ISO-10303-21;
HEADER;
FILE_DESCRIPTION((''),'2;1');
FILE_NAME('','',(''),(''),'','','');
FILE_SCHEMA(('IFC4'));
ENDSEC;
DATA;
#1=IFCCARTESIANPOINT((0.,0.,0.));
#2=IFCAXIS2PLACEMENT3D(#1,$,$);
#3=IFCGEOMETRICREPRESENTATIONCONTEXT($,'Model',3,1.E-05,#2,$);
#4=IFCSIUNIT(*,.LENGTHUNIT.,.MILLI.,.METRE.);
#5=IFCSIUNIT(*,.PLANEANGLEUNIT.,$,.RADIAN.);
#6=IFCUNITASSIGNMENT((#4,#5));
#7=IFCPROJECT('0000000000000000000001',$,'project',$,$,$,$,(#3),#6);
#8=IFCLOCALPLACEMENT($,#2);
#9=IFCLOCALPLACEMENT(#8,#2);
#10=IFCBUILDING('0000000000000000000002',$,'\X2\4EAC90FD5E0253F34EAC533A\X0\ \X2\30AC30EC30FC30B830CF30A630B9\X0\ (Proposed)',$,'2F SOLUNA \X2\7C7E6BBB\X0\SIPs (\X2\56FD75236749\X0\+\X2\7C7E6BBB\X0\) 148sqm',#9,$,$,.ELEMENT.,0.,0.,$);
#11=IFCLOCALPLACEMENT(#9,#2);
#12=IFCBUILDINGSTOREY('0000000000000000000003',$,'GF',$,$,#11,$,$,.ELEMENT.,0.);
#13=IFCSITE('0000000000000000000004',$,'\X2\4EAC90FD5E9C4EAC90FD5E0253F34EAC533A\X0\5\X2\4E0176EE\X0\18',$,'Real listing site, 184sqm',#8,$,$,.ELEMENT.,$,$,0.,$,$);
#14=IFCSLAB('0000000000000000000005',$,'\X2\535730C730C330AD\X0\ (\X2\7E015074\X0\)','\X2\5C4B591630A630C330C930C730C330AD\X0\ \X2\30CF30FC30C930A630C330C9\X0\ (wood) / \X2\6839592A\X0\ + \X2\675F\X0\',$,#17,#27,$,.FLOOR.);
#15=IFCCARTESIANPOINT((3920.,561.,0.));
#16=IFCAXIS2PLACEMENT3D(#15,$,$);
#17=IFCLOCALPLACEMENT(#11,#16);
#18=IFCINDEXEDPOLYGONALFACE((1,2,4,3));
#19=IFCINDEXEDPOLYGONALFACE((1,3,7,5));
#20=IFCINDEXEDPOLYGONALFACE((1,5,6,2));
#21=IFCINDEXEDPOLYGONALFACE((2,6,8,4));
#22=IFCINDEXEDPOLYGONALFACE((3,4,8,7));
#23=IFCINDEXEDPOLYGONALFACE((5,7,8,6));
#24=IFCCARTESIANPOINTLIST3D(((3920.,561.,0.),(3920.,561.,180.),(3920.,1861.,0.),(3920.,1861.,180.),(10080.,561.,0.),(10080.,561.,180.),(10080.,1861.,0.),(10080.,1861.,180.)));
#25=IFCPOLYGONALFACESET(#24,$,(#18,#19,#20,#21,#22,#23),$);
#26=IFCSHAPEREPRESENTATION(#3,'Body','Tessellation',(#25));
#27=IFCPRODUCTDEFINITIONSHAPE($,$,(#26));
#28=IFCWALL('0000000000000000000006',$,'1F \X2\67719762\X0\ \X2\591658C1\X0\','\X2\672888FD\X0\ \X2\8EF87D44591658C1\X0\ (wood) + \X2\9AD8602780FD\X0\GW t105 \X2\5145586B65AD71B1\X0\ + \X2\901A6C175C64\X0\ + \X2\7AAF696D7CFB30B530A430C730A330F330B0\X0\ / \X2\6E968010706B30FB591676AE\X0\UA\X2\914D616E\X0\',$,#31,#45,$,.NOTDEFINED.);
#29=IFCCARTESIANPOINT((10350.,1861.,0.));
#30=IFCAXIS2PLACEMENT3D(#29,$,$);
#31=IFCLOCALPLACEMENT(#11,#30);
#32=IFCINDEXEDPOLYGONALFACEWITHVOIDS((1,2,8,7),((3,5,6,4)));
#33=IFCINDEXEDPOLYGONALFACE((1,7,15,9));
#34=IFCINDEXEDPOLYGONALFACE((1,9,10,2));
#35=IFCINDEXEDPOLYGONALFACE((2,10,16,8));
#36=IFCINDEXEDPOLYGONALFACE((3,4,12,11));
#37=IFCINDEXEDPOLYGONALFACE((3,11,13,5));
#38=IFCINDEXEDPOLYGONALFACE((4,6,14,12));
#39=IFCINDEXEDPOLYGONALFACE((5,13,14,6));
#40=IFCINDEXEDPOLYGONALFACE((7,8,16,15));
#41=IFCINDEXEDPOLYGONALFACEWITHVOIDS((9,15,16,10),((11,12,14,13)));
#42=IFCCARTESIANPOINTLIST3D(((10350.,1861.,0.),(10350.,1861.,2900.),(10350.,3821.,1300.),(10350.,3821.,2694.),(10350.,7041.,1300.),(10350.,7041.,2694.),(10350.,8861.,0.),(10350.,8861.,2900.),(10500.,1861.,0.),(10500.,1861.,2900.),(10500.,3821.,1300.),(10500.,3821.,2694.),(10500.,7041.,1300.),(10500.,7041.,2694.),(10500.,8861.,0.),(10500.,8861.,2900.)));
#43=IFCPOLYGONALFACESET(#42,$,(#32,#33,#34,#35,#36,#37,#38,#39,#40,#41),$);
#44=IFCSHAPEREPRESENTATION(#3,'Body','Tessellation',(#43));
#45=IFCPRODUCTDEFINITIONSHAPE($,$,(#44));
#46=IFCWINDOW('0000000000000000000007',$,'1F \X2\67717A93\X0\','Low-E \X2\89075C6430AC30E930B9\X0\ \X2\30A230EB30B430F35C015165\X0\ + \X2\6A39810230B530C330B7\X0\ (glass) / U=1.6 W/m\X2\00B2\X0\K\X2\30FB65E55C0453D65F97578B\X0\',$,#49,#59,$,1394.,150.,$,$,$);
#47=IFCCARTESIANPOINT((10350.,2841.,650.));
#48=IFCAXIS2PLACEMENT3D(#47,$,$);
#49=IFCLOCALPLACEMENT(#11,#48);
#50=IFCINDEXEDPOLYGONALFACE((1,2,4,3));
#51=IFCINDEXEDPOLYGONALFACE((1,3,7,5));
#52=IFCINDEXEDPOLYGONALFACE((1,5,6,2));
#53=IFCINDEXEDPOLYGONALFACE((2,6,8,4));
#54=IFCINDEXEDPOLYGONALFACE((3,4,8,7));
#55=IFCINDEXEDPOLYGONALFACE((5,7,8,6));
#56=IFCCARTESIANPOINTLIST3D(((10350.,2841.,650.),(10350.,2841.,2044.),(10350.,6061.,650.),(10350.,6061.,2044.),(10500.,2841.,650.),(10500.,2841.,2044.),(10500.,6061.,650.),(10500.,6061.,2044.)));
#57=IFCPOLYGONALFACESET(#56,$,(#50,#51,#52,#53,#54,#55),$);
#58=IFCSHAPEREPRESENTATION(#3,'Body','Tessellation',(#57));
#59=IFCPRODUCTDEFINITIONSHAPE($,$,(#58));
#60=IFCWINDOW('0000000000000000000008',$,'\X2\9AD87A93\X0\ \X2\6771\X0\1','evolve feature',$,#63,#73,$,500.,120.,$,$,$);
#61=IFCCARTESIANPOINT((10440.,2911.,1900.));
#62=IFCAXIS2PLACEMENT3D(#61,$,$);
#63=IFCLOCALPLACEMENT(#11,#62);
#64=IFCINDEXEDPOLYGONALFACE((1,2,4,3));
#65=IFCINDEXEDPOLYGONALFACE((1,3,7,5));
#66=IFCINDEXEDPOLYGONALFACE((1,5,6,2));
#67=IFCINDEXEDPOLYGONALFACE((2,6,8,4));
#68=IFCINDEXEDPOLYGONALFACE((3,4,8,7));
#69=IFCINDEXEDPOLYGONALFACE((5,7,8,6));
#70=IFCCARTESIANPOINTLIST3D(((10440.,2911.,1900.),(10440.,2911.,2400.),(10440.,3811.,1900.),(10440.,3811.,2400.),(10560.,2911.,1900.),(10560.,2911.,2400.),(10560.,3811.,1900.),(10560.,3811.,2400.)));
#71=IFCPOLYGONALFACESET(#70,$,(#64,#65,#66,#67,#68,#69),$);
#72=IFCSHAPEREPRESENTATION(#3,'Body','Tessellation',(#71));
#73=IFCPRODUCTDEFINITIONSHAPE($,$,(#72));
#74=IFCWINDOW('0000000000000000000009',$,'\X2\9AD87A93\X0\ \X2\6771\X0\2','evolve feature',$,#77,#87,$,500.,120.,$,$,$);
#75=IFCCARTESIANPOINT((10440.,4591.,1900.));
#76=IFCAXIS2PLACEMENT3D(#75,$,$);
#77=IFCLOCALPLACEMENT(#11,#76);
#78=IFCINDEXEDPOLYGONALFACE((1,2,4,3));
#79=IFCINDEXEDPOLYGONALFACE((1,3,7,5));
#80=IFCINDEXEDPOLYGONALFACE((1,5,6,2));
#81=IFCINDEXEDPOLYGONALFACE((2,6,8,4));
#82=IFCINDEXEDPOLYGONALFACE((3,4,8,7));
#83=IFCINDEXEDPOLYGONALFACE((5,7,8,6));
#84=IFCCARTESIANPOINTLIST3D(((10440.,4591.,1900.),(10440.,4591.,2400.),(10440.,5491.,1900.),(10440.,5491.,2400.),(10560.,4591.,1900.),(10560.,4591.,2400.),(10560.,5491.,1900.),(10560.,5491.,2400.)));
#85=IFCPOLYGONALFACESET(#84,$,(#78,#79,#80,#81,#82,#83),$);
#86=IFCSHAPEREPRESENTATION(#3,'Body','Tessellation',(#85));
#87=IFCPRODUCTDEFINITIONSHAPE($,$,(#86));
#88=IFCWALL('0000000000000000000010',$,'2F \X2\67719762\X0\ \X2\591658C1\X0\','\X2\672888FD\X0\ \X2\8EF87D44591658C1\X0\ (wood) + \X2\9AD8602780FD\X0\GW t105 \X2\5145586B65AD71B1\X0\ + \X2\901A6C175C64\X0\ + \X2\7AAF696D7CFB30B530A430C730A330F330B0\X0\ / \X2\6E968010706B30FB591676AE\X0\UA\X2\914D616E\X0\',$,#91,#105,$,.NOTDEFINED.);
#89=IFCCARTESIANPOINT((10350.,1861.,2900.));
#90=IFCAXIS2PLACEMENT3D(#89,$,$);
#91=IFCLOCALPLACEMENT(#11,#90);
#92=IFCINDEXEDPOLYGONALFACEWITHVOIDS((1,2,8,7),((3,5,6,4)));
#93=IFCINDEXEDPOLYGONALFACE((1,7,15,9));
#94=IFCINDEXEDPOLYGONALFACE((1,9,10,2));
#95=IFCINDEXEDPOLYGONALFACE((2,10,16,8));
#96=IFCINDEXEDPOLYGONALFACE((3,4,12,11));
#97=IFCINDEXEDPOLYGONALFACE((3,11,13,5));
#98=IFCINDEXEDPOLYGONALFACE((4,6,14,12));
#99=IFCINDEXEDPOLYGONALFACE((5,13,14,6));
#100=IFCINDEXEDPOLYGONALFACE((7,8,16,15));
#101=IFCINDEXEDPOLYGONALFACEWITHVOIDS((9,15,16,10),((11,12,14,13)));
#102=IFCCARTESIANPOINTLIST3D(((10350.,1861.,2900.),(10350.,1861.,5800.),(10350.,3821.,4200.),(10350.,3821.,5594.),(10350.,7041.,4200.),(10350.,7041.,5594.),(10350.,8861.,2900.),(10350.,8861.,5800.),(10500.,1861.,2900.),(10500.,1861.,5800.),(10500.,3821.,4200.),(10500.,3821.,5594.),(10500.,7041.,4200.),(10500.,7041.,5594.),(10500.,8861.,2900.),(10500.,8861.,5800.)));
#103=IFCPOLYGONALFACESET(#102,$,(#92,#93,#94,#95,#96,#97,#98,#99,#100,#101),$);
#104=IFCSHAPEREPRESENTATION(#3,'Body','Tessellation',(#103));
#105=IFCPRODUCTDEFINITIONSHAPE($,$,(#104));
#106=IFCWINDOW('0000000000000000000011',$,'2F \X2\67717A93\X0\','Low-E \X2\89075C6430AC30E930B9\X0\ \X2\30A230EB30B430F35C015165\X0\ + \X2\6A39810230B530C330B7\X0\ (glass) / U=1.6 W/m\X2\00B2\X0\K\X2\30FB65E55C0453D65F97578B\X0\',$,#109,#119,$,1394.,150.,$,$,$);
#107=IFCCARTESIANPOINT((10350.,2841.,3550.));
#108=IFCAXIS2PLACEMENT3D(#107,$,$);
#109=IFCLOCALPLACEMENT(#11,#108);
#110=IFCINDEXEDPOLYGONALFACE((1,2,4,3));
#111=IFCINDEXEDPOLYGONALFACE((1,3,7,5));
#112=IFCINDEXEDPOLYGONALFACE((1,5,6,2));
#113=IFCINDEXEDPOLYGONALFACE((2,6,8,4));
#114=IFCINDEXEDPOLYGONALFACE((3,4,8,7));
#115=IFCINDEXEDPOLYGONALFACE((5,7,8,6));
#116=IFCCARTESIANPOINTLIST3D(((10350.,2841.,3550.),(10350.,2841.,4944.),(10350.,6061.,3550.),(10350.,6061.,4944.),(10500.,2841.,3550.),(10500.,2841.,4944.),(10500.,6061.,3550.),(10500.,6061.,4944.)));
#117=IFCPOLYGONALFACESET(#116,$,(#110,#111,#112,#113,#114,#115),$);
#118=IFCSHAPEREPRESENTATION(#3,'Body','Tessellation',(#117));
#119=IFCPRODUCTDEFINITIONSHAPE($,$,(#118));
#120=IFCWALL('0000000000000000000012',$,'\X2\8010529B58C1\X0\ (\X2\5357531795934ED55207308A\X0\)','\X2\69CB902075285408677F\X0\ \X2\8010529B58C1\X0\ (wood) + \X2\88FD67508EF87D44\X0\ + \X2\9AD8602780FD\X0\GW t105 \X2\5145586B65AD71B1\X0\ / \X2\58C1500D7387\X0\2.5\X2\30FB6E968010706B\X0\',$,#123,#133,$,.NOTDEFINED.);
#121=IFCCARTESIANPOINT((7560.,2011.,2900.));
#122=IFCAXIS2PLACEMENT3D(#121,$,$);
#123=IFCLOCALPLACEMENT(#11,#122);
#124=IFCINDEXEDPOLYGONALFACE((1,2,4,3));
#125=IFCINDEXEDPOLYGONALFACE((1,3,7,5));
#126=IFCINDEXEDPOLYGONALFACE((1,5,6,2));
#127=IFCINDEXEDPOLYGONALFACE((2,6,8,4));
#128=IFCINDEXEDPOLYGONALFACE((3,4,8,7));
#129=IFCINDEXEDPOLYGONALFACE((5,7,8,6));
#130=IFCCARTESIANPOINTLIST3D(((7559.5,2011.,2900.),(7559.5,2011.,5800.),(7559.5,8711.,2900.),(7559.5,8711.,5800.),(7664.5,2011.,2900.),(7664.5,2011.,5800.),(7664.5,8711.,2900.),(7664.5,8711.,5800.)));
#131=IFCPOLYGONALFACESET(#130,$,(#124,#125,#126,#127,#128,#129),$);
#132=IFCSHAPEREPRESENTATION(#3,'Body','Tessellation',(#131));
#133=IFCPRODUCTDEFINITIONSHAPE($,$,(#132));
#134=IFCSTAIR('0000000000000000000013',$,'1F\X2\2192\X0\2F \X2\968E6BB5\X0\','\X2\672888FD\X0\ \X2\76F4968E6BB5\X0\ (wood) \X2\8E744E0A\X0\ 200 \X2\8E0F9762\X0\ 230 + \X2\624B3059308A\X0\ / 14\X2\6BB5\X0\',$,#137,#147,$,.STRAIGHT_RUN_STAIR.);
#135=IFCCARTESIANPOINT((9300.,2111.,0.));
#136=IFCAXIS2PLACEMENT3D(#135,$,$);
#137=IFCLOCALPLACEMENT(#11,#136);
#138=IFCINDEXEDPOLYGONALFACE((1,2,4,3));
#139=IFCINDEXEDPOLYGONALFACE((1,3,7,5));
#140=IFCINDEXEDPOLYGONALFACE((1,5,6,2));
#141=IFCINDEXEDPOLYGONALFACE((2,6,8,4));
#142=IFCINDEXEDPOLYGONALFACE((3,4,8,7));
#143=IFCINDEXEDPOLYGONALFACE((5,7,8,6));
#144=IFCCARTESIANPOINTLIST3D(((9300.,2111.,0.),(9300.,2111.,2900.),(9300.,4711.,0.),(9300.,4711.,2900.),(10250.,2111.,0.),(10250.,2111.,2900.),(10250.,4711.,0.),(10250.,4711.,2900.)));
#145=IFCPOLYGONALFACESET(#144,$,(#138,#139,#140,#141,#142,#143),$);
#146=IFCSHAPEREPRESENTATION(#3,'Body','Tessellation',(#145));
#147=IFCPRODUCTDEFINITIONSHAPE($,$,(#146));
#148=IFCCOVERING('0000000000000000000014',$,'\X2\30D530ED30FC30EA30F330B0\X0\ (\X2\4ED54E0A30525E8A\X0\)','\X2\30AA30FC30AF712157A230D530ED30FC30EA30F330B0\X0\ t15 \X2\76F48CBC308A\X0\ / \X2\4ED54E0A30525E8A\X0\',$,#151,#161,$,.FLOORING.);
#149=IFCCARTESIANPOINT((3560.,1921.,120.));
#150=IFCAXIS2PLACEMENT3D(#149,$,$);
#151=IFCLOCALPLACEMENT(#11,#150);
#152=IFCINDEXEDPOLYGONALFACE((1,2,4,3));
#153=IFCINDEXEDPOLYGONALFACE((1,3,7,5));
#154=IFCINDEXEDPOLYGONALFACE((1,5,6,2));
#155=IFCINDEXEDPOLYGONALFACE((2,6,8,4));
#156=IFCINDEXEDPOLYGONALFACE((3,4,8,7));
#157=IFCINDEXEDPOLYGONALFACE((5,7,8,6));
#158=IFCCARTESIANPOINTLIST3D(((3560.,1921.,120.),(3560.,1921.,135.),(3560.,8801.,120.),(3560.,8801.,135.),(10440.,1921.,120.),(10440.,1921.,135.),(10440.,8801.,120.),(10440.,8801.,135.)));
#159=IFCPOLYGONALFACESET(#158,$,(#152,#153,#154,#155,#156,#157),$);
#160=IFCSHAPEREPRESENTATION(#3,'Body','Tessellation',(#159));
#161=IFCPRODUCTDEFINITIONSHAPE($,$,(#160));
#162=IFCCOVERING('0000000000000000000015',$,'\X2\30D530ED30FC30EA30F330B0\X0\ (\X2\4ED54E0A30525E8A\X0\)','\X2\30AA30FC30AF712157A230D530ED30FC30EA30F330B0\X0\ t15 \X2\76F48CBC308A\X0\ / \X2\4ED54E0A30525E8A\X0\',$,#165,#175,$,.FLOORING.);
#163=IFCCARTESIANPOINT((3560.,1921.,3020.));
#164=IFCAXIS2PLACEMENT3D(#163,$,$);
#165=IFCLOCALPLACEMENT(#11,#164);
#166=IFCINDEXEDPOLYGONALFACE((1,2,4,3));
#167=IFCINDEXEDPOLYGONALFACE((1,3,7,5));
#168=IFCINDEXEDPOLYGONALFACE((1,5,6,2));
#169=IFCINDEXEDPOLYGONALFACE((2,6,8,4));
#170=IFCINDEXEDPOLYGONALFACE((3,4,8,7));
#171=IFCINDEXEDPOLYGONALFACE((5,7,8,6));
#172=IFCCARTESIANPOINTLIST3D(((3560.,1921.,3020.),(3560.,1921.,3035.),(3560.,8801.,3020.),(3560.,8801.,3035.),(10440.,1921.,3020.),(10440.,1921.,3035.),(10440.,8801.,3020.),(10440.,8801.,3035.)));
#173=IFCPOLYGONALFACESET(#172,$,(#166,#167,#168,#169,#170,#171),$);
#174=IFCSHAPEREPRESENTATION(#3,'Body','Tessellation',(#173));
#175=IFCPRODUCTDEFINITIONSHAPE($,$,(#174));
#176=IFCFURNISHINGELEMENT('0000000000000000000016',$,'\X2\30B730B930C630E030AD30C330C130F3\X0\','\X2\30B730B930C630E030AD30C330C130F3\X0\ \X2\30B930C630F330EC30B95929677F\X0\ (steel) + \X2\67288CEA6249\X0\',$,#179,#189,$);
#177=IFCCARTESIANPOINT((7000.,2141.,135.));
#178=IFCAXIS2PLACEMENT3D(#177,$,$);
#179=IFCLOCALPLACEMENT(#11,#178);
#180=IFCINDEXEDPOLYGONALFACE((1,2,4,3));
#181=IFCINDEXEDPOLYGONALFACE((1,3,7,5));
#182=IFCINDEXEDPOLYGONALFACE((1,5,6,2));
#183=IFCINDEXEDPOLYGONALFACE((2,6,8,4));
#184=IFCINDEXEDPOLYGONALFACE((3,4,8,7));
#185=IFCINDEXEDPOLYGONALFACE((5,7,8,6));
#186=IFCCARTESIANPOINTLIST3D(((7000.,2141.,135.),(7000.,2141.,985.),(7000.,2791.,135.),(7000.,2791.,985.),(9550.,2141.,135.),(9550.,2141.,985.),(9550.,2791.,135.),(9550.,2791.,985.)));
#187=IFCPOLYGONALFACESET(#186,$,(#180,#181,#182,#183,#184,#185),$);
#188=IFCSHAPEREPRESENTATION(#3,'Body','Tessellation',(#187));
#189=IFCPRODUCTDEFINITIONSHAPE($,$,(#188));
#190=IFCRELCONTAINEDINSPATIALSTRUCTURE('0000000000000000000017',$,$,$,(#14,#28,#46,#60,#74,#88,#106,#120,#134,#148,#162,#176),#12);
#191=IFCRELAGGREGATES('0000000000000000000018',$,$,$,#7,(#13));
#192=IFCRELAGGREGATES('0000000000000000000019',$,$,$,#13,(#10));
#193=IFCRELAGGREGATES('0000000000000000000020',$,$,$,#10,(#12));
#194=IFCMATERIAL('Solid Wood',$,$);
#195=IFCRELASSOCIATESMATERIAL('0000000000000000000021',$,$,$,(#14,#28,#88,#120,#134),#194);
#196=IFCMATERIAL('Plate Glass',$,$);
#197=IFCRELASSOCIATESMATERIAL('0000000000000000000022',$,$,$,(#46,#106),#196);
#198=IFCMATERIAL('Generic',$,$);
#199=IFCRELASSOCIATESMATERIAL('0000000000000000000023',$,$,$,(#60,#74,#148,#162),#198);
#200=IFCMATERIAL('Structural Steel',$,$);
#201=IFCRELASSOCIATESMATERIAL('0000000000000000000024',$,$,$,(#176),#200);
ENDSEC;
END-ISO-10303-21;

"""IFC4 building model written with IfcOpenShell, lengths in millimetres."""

from ifc_helpers import new_model, si_unit, frame, frame_2d, origin, place, context, project, spatial, rectangle, extrude, material, element, fill, save


model = new_model("IFC4")

# Units and contexts
model_context = context("Model", 3, precision=1e-05, world=origin())
ifc_project = project(units=[si_unit("LENGTHUNIT", "METRE", prefix="MILLI"), si_unit("PLANEANGLEUNIT", "RADIAN")], contexts=[model_context])

# Site, building, storey
site_placement = place(None, origin())
site = spatial("IfcSite", under=ifc_project, at=site_placement, Name="京都府京都市右京区5丁目18", ObjectType="Real listing site, 184sqm", CompositionType="ELEMENT", RefElevation=0.0)
building_placement = place(site_placement, origin())
building = spatial("IfcBuilding", under=site, at=building_placement, Name="京都市右京区 ガレージハウス (Proposed)", ObjectType="2F SOLUNA 籾殻SIPs (国産杉+籾殻) 148sqm", CompositionType="ELEMENT", ElevationOfRefHeight=0.0, ElevationOfTerrain=0.0)
storey_placement = place(building_placement, origin())
storey = spatial("IfcBuildingStorey", under=building, at=storey_placement, Name="GF", CompositionType="ELEMENT", Elevation=0.0)

# Slab
ifc_material_1 = material(Name="Solid Wood")
slab_placement = place(storey_placement, frame((3920.0, 561.0, 0.0)))
element("IfcSlab", 1, at=slab_placement, inside=storey, material=ifc_material_1, Name="南デッキ (縁側)", Description="屋外ウッドデッキ ハードウッド (wood) / 根太 + 束", PredefinedType="FLOOR", context=model_context, shape_type="SweptSolid", body=[
    extrude(rectangle(XDim=6160.0, YDim=1300.0, at=frame_2d((3080.0, 650.0))), frame((3920.0, 561.0, 0.0)), (0.0, 0.0, 1.0), 180.0),
])

# Wall, openings, windows
wall_1_placement = place(storey_placement, frame((10350.0, 1861.0, 0.0)))
wall_1 = element("IfcWall", 2, at=wall_1_placement, inside=storey, material=ifc_material_1, Name="1F 東面 外壁", Description="木製 軸組外壁 (wood) + 高性能GW t105 充填断熱 + 通気層 + 窯業系サイディング / 準耐火・外皮UA配慮", PredefinedType="NOTDEFINED", context=model_context, shape_type="SweptSolid", body=[
    extrude(rectangle(XDim=150.0, YDim=7000.0, at=frame_2d((75.0, 3500.0))), frame((10350.0, 1861.0, 0.0)), (0.0, 0.0, 1.0), 2900.0),
])
opening_1_placement = place(storey_placement, frame((10350.0, 2841.0, 650.0)))
opening_1 = element("IfcOpeningElement", 3, at=opening_1_placement, cuts=wall_1, PredefinedType="NOTDEFINED", context=model_context, shape_type="SweptSolid", body=[
    extrude(rectangle(XDim=150.0, YDim=3220.0, at=frame_2d((75.0, 1610.0))), frame((10350.0, 2841.0, 650.0)), (0.0, 0.0, 1.0), 1394.0),
])
opening_2_placement = place(storey_placement, frame((10440.0, 2911.0, 1900.0)))
opening_2 = element("IfcOpeningElement", 4, at=opening_2_placement, cuts=wall_1, PredefinedType="NOTDEFINED", context=model_context, shape_type="SweptSolid", body=[
    extrude(rectangle(XDim=120.0, YDim=900.0, at=frame_2d((60.0, 450.0))), frame((10440.0, 2911.0, 1900.0)), (0.0, 0.0, 1.0), 500.0),
])
opening_3_placement = place(storey_placement, frame((10440.0, 4591.0, 1900.0)))
opening_3 = element("IfcOpeningElement", 5, at=opening_3_placement, cuts=wall_1, PredefinedType="NOTDEFINED", context=model_context, shape_type="SweptSolid", body=[
    extrude(rectangle(XDim=120.0, YDim=900.0, at=frame_2d((60.0, 450.0))), frame((10440.0, 4591.0, 1900.0)), (0.0, 0.0, 1.0), 500.0),
])
ifc_material_2 = material(Name="Plate Glass")
window_1_placement = place(storey_placement, frame((10350.0, 2841.0, 650.0)))
window_1 = element("IfcWindow", 6, at=window_1_placement, inside=storey, material=ifc_material_2, Name="1F 東窓", Description="Low-E 複層ガラス アルゴン封入 + 樹脂サッシ (glass) / U=1.6 W/m²K・日射取得型", OverallHeight=1394.0, OverallWidth=150.0, context=model_context, shape_type="SweptSolid", body=[
    extrude(rectangle(XDim=150.0, YDim=3220.0, at=frame_2d((75.0, 1610.0))), frame((10350.0, 2841.0, 650.0)), (0.0, 0.0, 1.0), 1394.0),
])
fill(opening_1, window_1)
ifc_material_3 = material(Name="Generic")
window_2_placement = place(storey_placement, frame((10440.0, 2911.0, 1900.0)))
window_2 = element("IfcWindow", 7, at=window_2_placement, inside=storey, material=ifc_material_3, Name="高窓 東1", Description="evolve feature", OverallHeight=500.0, OverallWidth=120.0, context=model_context, shape_type="SweptSolid", body=[
    extrude(rectangle(XDim=120.0, YDim=900.0, at=frame_2d((60.0, 450.0))), frame((10440.0, 2911.0, 1900.0)), (0.0, 0.0, 1.0), 500.0),
])
fill(opening_2, window_2)
window_3_placement = place(storey_placement, frame((10440.0, 4591.0, 1900.0)))
window_3 = element("IfcWindow", 8, at=window_3_placement, inside=storey, material=ifc_material_3, Name="高窓 東2", Description="evolve feature", OverallHeight=500.0, OverallWidth=120.0, context=model_context, shape_type="SweptSolid", body=[
    extrude(rectangle(XDim=120.0, YDim=900.0, at=frame_2d((60.0, 450.0))), frame((10440.0, 4591.0, 1900.0)), (0.0, 0.0, 1.0), 500.0),
])
fill(opening_3, window_3)

# Wall, opening, window
wall_2_placement = place(storey_placement, frame((10350.0, 1861.0, 2900.0)))
wall_2 = element("IfcWall", 9, at=wall_2_placement, inside=storey, material=ifc_material_1, Name="2F 東面 外壁", Description="木製 軸組外壁 (wood) + 高性能GW t105 充填断熱 + 通気層 + 窯業系サイディング / 準耐火・外皮UA配慮", PredefinedType="NOTDEFINED", context=model_context, shape_type="SweptSolid", body=[
    extrude(rectangle(XDim=150.0, YDim=7000.0, at=frame_2d((75.0, 3500.0))), frame((10350.0, 1861.0, 2900.0)), (0.0, 0.0, 1.0), 2900.0),
])
opening_4_placement = place(storey_placement, frame((10350.0, 2841.0, 3550.0)))
opening_4 = element("IfcOpeningElement", 10, at=opening_4_placement, cuts=wall_2, PredefinedType="NOTDEFINED", context=model_context, shape_type="SweptSolid", body=[
    extrude(rectangle(XDim=150.0, YDim=3220.0, at=frame_2d((75.0, 1610.0))), frame((10350.0, 2841.0, 3550.0)), (0.0, 0.0, 1.0), 1394.0),
])
window_4_placement = place(storey_placement, frame((10350.0, 2841.0, 3550.0)))
window_4 = element("IfcWindow", 11, at=window_4_placement, inside=storey, material=ifc_material_2, Name="2F 東窓", Description="Low-E 複層ガラス アルゴン封入 + 樹脂サッシ (glass) / U=1.6 W/m²K・日射取得型", OverallHeight=1394.0, OverallWidth=150.0, context=model_context, shape_type="SweptSolid", body=[
    extrude(rectangle(XDim=150.0, YDim=3220.0, at=frame_2d((75.0, 1610.0))), frame((10350.0, 2841.0, 3550.0)), (0.0, 0.0, 1.0), 1394.0),
])
fill(opening_4, window_4)

# Wall
wall_3_placement = place(storey_placement, frame((7560.0, 2011.0, 2900.0)))
element("IfcWall", 12, at=wall_3_placement, inside=storey, material=ifc_material_1, Name="耐力壁 (南北間仕切り)", Description="構造用合板 耐力壁 (wood) + 製材軸組 + 高性能GW t105 充填断熱 / 壁倍率2.5・準耐火", PredefinedType="NOTDEFINED", context=model_context, shape_type="SweptSolid", body=[
    extrude(rectangle(XDim=105.0, YDim=6700.0, at=frame_2d((52.0, 3350.0))), frame((7560.0, 2011.0, 2900.0)), (0.0, 0.0, 1.0), 2900.0),
])

# Stair
stair_placement = place(storey_placement, frame((9300.0, 2111.0, 0.0)))
element("IfcStair", 13, at=stair_placement, inside=storey, material=ifc_material_1, Name="1F→2F 階段", Description="木製 直階段 (wood) 蹴上 200 踏面 230 + 手すり / 14段", PredefinedType="STRAIGHT_RUN_STAIR", context=model_context, shape_type="SweptSolid", body=[
    extrude(rectangle(XDim=950.0, YDim=2600.0, at=frame_2d((475.0, 1300.0))), frame((9300.0, 2111.0, 0.0)), (0.0, 0.0, 1.0), 2900.0),
])

# Coverings
covering_1_placement = place(storey_placement, frame((3560.0, 1921.0, 120.0)))
element("IfcCovering", 14, at=covering_1_placement, inside=storey, material=ifc_material_3, Name="フローリング (仕上げ床)", Description="オーク無垢フローリング t15 直貼り / 仕上げ床", PredefinedType="FLOORING", context=model_context, shape_type="SweptSolid", body=[
    extrude(rectangle(XDim=6880.0, YDim=6880.0, at=frame_2d((3440.0, 3440.0))), frame((3560.0, 1921.0, 120.0)), (0.0, 0.0, 1.0), 15.0),
])
covering_2_placement = place(storey_placement, frame((3560.0, 1921.0, 3020.0)))
element("IfcCovering", 15, at=covering_2_placement, inside=storey, material=ifc_material_3, Name="フローリング (仕上げ床)", Description="オーク無垢フローリング t15 直貼り / 仕上げ床", PredefinedType="FLOORING", context=model_context, shape_type="SweptSolid", body=[
    extrude(rectangle(XDim=6880.0, YDim=6880.0, at=frame_2d((3440.0, 3440.0))), frame((3560.0, 1921.0, 3020.0)), (0.0, 0.0, 1.0), 15.0),
])

# Furnishing element
ifc_material_4 = material(Name="Structural Steel")
furnishing_1_placement = place(storey_placement, frame((7000.0, 2141.0, 135.0)))
element("IfcFurnishingElement", 16, at=furnishing_1_placement, inside=storey, material=ifc_material_4, Name="システムキッチン", Description="システムキッチン ステンレス天板 (steel) + 木質扉", context=model_context, shape_type="SweptSolid", body=[
    extrude(rectangle(XDim=2550.0, YDim=650.0, at=frame_2d((1275.0, 325.0))), frame((7000.0, 2141.0, 135.0)), (0.0, 0.0, 1.0), 850.0),
])

save(model, "model.ifc")
